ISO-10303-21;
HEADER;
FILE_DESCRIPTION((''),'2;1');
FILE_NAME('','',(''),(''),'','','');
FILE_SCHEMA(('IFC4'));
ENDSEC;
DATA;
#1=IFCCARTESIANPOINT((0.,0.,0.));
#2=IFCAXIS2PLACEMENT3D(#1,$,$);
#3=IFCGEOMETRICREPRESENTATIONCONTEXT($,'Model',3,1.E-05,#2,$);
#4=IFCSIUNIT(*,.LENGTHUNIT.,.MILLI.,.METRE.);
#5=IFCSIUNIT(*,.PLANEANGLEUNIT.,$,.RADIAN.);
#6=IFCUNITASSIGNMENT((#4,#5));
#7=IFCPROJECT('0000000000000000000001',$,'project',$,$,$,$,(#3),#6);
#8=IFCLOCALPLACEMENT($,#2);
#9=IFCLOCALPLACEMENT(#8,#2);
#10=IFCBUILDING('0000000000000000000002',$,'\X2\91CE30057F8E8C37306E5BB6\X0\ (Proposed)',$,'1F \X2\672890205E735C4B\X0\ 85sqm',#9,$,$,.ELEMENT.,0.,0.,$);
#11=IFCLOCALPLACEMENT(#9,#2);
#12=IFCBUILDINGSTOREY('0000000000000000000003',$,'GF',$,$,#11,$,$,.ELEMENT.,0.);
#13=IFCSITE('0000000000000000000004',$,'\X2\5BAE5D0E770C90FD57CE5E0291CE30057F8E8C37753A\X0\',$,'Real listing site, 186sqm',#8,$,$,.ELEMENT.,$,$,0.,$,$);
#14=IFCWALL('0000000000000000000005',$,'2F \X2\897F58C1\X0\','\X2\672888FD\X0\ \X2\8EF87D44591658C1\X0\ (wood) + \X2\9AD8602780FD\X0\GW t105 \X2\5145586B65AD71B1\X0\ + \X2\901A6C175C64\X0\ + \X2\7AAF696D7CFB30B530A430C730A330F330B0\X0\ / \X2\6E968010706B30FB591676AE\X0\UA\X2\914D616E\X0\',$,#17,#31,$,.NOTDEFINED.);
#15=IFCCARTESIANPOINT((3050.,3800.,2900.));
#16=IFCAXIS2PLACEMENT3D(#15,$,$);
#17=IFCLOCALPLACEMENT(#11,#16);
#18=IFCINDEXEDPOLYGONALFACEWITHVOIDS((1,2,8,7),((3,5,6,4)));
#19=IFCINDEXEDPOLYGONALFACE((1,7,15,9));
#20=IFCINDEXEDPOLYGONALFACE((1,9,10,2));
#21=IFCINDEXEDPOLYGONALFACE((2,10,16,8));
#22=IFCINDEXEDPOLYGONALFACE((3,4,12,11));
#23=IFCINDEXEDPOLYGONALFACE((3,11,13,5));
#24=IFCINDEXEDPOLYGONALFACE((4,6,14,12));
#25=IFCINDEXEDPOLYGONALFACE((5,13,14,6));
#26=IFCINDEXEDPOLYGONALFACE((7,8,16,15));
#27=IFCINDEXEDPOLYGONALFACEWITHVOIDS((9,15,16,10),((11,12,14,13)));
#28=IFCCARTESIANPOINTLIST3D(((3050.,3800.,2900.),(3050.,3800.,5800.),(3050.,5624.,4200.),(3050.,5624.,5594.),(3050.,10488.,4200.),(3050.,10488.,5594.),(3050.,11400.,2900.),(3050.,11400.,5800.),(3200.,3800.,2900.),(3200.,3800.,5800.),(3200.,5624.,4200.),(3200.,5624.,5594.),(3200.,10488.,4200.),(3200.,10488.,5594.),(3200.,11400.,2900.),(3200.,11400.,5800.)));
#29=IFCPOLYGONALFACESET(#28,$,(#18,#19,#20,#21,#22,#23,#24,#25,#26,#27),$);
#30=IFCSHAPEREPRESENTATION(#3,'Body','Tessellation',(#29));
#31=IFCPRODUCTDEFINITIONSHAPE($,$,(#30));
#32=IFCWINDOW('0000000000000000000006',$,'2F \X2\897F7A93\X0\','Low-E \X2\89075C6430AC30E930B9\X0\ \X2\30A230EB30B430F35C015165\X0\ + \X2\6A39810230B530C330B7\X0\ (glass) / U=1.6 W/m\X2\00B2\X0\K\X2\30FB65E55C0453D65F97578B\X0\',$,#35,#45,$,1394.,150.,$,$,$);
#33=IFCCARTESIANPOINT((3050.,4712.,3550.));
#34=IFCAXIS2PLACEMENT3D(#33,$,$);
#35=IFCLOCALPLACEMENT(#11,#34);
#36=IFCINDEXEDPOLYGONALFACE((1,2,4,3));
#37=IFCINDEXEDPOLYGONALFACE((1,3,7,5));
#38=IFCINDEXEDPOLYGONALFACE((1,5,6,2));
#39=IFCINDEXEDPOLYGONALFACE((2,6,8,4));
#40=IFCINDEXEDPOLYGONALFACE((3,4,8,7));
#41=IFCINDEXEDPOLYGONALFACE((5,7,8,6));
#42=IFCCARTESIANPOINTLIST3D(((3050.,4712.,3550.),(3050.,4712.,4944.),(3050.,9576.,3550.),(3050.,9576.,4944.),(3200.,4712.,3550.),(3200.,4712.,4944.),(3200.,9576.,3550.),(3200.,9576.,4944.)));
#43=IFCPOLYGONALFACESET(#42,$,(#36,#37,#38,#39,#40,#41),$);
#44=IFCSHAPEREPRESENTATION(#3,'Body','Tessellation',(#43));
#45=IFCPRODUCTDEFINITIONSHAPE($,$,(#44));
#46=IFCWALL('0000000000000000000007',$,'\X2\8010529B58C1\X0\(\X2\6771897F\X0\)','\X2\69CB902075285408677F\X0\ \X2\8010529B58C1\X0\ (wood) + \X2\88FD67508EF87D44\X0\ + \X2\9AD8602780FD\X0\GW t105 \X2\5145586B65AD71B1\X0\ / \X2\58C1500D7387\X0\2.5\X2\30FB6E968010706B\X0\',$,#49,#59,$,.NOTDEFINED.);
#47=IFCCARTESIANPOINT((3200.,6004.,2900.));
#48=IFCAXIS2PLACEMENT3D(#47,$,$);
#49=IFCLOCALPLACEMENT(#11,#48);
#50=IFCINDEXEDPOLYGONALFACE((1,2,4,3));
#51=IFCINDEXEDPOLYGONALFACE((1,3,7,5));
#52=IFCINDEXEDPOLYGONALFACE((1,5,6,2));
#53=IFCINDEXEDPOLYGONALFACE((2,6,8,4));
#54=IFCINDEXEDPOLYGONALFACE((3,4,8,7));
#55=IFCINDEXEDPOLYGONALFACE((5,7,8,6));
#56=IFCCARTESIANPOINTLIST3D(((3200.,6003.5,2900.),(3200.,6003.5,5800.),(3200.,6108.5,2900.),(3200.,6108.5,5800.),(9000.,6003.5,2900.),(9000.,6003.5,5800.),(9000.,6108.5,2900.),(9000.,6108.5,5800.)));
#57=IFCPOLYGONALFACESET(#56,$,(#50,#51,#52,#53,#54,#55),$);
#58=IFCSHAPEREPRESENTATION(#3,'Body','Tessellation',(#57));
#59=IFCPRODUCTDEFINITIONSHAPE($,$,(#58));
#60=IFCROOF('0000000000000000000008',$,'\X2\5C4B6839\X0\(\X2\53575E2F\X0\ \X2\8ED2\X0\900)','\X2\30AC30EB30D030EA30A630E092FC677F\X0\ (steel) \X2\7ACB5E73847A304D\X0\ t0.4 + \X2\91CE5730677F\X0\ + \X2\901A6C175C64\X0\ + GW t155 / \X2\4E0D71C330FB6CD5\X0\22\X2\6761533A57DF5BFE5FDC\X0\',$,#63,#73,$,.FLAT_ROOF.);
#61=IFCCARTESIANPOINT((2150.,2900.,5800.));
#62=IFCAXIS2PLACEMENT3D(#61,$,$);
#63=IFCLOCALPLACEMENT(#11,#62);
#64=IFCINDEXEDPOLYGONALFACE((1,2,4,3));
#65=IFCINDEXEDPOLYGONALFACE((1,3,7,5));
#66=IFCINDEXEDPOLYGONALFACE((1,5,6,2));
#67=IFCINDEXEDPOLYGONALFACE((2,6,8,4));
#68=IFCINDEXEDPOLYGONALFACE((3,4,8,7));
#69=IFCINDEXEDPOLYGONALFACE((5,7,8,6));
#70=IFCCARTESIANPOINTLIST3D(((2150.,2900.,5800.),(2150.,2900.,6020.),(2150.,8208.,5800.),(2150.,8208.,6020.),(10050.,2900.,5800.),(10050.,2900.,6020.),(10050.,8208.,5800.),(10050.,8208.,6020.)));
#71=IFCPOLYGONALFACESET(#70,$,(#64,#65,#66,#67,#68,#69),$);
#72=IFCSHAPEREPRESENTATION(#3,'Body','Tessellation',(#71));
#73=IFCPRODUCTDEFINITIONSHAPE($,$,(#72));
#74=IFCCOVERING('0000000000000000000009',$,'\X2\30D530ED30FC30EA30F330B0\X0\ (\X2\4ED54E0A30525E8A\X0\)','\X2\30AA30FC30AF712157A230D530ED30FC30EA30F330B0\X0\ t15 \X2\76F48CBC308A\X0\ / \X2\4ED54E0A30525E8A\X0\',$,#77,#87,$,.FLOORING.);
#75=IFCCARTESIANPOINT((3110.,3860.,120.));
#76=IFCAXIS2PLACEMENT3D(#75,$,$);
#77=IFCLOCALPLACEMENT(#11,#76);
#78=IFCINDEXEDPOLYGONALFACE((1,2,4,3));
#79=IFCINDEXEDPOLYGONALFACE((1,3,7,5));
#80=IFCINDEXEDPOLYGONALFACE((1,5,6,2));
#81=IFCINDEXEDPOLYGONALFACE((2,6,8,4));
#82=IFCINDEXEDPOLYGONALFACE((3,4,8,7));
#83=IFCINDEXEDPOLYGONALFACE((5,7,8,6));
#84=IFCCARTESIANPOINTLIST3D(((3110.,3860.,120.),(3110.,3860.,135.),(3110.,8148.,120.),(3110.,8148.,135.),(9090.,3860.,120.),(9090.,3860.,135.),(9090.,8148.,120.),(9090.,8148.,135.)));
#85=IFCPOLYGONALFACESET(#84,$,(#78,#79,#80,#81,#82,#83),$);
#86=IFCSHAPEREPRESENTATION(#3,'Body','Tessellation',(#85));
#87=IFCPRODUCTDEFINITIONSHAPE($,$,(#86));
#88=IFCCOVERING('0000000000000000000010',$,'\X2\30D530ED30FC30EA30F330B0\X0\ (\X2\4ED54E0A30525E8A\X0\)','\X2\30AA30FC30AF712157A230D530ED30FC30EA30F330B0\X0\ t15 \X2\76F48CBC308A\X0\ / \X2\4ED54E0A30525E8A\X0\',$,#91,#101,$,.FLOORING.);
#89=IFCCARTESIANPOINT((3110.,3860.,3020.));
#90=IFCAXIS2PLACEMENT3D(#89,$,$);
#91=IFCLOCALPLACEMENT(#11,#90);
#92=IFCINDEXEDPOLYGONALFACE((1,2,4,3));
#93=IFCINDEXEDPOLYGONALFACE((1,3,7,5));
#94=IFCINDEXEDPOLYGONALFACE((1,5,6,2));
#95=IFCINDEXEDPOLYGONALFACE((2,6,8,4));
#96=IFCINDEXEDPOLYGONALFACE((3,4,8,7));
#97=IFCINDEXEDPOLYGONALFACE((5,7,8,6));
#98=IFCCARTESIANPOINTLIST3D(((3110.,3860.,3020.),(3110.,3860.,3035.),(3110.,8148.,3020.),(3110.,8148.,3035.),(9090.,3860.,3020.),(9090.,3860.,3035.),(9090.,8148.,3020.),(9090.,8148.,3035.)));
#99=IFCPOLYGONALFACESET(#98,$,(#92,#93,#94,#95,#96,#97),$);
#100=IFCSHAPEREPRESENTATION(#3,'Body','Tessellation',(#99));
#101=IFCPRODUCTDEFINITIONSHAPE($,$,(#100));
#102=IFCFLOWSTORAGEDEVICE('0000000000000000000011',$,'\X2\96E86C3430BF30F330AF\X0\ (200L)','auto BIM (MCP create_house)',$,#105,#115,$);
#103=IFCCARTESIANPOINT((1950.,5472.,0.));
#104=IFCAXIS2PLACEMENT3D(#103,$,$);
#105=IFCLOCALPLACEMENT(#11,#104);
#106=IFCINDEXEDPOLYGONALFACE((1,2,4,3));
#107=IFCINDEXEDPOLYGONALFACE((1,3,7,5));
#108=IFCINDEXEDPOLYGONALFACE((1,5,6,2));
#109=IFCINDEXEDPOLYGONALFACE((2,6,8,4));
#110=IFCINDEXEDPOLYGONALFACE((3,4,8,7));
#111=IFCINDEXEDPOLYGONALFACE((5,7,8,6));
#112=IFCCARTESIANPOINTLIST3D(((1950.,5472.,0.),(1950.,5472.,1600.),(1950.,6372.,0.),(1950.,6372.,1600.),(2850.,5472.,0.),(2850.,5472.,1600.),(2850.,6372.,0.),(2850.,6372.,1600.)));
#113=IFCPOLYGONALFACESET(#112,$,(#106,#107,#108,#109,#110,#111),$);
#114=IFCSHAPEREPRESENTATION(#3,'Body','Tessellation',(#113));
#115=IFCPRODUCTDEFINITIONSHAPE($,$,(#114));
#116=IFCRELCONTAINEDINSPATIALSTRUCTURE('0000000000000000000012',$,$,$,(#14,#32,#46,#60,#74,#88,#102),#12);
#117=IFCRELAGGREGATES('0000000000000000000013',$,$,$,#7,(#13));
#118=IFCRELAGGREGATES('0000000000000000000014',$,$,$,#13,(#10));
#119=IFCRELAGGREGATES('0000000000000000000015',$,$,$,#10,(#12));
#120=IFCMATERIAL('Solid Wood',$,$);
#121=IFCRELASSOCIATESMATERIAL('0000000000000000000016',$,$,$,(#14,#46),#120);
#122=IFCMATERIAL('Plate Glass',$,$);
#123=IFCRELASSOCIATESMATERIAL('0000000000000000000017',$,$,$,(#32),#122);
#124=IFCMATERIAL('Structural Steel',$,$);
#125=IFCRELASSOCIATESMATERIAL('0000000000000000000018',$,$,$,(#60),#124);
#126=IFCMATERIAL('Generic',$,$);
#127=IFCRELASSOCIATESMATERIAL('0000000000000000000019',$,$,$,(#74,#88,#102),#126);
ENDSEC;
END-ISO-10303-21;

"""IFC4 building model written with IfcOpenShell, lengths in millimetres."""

from ifc_helpers import new_model, si_unit, frame, frame_2d, origin, place, context, project, spatial, rectangle, extrude, material, element, fill, save


model = new_model("IFC4")

# Units and contexts
model_context = context("Model", 3, precision=1e-05, world=origin())
ifc_project = project(units=[si_unit("LENGTHUNIT", "METRE", prefix="MILLI"), si_unit("PLANEANGLEUNIT", "RADIAN")], contexts=[model_context])

# Site, building, storey
site_placement = place(None, origin())
site = spatial("IfcSite", under=ifc_project, at=site_placement, Name="宮崎県都城市野々美谷町", ObjectType="Real listing site, 186sqm", CompositionType="ELEMENT", RefElevation=0.0)
building_placement = place(site_placement, origin())
building = spatial("IfcBuilding", under=site, at=building_placement, Name="野々美谷の家 (Proposed)", ObjectType="1F 木造平屋 85sqm", CompositionType="ELEMENT", ElevationOfRefHeight=0.0, ElevationOfTerrain=0.0)
storey_placement = place(building_placement, origin())
storey = spatial("IfcBuildingStorey", under=building, at=storey_placement, Name="GF", CompositionType="ELEMENT", Elevation=0.0)

# Shared definitions
ifc_material_1 = material(Name="Solid Wood")
ifc_material_2 = material(Name="Generic")

# Shared definitions
ifc_material_3 = material(Name="Plate Glass")

# Wall, opening, window
wall_1_placement = place(storey_placement, frame((3050.0, 3800.0, 2900.0)))
wall_1 = element("IfcWall", 1, at=wall_1_placement, inside=storey, material=ifc_material_1, Name="2F 西壁", Description="木製 軸組外壁 (wood) + 高性能GW t105 充填断熱 + 通気層 + 窯業系サイディング / 準耐火・外皮UA配慮", PredefinedType="NOTDEFINED", context=model_context, shape_type="SweptSolid", body=[
    extrude(rectangle(XDim=150.0, YDim=7600.0, at=frame_2d((75.0, 3800.0))), frame((3050.0, 3800.0, 2900.0)), (0.0, 0.0, 1.0), 2900.0),
])
opening_1_placement = place(storey_placement, frame((3050.0, 4712.0, 3550.0)))
opening_1 = element("IfcOpeningElement", 2, at=opening_1_placement, cuts=wall_1, PredefinedType="NOTDEFINED", context=model_context, shape_type="SweptSolid", body=[
    extrude(rectangle(XDim=150.0, YDim=4864.0, at=frame_2d((75.0, 2432.0))), frame((3050.0, 4712.0, 3550.0)), (0.0, 0.0, 1.0), 1394.0),
])
window_1_placement = place(storey_placement, frame((3050.0, 4712.0, 3550.0)))
window_1 = element("IfcWindow", 3, at=window_1_placement, inside=storey, material=ifc_material_3, Name="2F 西窓", Description="Low-E 複層ガラス アルゴン封入 + 樹脂サッシ (glass) / U=1.6 W/m²K・日射取得型", OverallHeight=1394.0, OverallWidth=150.0, context=model_context, shape_type="SweptSolid", body=[
    extrude(rectangle(XDim=150.0, YDim=4864.0, at=frame_2d((75.0, 2432.0))), frame((3050.0, 4712.0, 3550.0)), (0.0, 0.0, 1.0), 1394.0),
])
fill(opening_1, window_1)

# Wall
wall_2_placement = place(storey_placement, frame((3200.0, 6004.0, 2900.0)))
element("IfcWall", 4, at=wall_2_placement, inside=storey, material=ifc_material_1, Name="耐力壁(東西)", Description="構造用合板 耐力壁 (wood) + 製材軸組 + 高性能GW t105 充填断熱 / 壁倍率2.5・準耐火", PredefinedType="NOTDEFINED", context=model_context, shape_type="SweptSolid", body=[
    extrude(rectangle(XDim=5800.0, YDim=105.0, at=frame_2d((2900.0, 52.0))), frame((3200.0, 6004.0, 2900.0)), (0.0, 0.0, 1.0), 2900.0),
])

# Roof
ifc_material_4 = material(Name="Structural Steel")
for number, where, name in (
    (5, (2150.0, 2900.0, 5800.0), "屋根(南帯 軒900)"),
):
    element("IfcRoof", number, at=place(storey_placement, frame(where)), inside=storey, material=ifc_material_4, Name=name, Description="ガルバリウム鋼板 (steel) 立平葺き t0.4 + 野地板 + 通気層 + GW t155 / 不燃・法22条区域対応", PredefinedType="FLAT_ROOF", context=model_context, shape_type="SweptSolid", body=[
        extrude(rectangle(XDim=7900.0, YDim=5308.0, at=frame_2d((3950.0, 2654.0))), frame((2150.0, 2900.0, 5800.0)), (0.0, 0.0, 1.0), 220.0),
    ])

# Coverings
covering_1_placement = place(storey_placement, frame((3110.0, 3860.0, 120.0)))
element("IfcCovering", 6, at=covering_1_placement, inside=storey, material=ifc_material_2, Name="フローリング (仕上げ床)", Description="オーク無垢フローリング t15 直貼り / 仕上げ床", PredefinedType="FLOORING", context=model_context, shape_type="SweptSolid", body=[
    extrude(rectangle(XDim=5980.0, YDim=4288.0, at=frame_2d((2990.0, 2144.0))), frame((3110.0, 3860.0, 120.0)), (0.0, 0.0, 1.0), 15.0),
])
covering_2_placement = place(storey_placement, frame((3110.0, 3860.0, 3020.0)))
element("IfcCovering", 7, at=covering_2_placement, inside=storey, material=ifc_material_2, Name="フローリング (仕上げ床)", Description="オーク無垢フローリング t15 直貼り / 仕上げ床", PredefinedType="FLOORING", context=model_context, shape_type="SweptSolid", body=[
    extrude(rectangle(XDim=5980.0, YDim=4288.0, at=frame_2d((2990.0, 2144.0))), frame((3110.0, 3860.0, 3020.0)), (0.0, 0.0, 1.0), 15.0),
])

# Flow storage device
flow_storage_device_placement = place(storey_placement, frame((1950.0, 5472.0, 0.0)))
element("IfcFlowStorageDevice", 8, at=flow_storage_device_placement, inside=storey, material=ifc_material_2, Name="雨水タンク (200L)", Description="auto BIM (MCP create_house)", context=model_context, shape_type="SweptSolid", body=[
    extrude(rectangle(XDim=900.0, YDim=900.0, at=frame_2d((450.0, 450.0))), frame((1950.0, 5472.0, 0.0)), (0.0, 0.0, 1.0), 1600.0),
])

save(model, "model.ifc")
